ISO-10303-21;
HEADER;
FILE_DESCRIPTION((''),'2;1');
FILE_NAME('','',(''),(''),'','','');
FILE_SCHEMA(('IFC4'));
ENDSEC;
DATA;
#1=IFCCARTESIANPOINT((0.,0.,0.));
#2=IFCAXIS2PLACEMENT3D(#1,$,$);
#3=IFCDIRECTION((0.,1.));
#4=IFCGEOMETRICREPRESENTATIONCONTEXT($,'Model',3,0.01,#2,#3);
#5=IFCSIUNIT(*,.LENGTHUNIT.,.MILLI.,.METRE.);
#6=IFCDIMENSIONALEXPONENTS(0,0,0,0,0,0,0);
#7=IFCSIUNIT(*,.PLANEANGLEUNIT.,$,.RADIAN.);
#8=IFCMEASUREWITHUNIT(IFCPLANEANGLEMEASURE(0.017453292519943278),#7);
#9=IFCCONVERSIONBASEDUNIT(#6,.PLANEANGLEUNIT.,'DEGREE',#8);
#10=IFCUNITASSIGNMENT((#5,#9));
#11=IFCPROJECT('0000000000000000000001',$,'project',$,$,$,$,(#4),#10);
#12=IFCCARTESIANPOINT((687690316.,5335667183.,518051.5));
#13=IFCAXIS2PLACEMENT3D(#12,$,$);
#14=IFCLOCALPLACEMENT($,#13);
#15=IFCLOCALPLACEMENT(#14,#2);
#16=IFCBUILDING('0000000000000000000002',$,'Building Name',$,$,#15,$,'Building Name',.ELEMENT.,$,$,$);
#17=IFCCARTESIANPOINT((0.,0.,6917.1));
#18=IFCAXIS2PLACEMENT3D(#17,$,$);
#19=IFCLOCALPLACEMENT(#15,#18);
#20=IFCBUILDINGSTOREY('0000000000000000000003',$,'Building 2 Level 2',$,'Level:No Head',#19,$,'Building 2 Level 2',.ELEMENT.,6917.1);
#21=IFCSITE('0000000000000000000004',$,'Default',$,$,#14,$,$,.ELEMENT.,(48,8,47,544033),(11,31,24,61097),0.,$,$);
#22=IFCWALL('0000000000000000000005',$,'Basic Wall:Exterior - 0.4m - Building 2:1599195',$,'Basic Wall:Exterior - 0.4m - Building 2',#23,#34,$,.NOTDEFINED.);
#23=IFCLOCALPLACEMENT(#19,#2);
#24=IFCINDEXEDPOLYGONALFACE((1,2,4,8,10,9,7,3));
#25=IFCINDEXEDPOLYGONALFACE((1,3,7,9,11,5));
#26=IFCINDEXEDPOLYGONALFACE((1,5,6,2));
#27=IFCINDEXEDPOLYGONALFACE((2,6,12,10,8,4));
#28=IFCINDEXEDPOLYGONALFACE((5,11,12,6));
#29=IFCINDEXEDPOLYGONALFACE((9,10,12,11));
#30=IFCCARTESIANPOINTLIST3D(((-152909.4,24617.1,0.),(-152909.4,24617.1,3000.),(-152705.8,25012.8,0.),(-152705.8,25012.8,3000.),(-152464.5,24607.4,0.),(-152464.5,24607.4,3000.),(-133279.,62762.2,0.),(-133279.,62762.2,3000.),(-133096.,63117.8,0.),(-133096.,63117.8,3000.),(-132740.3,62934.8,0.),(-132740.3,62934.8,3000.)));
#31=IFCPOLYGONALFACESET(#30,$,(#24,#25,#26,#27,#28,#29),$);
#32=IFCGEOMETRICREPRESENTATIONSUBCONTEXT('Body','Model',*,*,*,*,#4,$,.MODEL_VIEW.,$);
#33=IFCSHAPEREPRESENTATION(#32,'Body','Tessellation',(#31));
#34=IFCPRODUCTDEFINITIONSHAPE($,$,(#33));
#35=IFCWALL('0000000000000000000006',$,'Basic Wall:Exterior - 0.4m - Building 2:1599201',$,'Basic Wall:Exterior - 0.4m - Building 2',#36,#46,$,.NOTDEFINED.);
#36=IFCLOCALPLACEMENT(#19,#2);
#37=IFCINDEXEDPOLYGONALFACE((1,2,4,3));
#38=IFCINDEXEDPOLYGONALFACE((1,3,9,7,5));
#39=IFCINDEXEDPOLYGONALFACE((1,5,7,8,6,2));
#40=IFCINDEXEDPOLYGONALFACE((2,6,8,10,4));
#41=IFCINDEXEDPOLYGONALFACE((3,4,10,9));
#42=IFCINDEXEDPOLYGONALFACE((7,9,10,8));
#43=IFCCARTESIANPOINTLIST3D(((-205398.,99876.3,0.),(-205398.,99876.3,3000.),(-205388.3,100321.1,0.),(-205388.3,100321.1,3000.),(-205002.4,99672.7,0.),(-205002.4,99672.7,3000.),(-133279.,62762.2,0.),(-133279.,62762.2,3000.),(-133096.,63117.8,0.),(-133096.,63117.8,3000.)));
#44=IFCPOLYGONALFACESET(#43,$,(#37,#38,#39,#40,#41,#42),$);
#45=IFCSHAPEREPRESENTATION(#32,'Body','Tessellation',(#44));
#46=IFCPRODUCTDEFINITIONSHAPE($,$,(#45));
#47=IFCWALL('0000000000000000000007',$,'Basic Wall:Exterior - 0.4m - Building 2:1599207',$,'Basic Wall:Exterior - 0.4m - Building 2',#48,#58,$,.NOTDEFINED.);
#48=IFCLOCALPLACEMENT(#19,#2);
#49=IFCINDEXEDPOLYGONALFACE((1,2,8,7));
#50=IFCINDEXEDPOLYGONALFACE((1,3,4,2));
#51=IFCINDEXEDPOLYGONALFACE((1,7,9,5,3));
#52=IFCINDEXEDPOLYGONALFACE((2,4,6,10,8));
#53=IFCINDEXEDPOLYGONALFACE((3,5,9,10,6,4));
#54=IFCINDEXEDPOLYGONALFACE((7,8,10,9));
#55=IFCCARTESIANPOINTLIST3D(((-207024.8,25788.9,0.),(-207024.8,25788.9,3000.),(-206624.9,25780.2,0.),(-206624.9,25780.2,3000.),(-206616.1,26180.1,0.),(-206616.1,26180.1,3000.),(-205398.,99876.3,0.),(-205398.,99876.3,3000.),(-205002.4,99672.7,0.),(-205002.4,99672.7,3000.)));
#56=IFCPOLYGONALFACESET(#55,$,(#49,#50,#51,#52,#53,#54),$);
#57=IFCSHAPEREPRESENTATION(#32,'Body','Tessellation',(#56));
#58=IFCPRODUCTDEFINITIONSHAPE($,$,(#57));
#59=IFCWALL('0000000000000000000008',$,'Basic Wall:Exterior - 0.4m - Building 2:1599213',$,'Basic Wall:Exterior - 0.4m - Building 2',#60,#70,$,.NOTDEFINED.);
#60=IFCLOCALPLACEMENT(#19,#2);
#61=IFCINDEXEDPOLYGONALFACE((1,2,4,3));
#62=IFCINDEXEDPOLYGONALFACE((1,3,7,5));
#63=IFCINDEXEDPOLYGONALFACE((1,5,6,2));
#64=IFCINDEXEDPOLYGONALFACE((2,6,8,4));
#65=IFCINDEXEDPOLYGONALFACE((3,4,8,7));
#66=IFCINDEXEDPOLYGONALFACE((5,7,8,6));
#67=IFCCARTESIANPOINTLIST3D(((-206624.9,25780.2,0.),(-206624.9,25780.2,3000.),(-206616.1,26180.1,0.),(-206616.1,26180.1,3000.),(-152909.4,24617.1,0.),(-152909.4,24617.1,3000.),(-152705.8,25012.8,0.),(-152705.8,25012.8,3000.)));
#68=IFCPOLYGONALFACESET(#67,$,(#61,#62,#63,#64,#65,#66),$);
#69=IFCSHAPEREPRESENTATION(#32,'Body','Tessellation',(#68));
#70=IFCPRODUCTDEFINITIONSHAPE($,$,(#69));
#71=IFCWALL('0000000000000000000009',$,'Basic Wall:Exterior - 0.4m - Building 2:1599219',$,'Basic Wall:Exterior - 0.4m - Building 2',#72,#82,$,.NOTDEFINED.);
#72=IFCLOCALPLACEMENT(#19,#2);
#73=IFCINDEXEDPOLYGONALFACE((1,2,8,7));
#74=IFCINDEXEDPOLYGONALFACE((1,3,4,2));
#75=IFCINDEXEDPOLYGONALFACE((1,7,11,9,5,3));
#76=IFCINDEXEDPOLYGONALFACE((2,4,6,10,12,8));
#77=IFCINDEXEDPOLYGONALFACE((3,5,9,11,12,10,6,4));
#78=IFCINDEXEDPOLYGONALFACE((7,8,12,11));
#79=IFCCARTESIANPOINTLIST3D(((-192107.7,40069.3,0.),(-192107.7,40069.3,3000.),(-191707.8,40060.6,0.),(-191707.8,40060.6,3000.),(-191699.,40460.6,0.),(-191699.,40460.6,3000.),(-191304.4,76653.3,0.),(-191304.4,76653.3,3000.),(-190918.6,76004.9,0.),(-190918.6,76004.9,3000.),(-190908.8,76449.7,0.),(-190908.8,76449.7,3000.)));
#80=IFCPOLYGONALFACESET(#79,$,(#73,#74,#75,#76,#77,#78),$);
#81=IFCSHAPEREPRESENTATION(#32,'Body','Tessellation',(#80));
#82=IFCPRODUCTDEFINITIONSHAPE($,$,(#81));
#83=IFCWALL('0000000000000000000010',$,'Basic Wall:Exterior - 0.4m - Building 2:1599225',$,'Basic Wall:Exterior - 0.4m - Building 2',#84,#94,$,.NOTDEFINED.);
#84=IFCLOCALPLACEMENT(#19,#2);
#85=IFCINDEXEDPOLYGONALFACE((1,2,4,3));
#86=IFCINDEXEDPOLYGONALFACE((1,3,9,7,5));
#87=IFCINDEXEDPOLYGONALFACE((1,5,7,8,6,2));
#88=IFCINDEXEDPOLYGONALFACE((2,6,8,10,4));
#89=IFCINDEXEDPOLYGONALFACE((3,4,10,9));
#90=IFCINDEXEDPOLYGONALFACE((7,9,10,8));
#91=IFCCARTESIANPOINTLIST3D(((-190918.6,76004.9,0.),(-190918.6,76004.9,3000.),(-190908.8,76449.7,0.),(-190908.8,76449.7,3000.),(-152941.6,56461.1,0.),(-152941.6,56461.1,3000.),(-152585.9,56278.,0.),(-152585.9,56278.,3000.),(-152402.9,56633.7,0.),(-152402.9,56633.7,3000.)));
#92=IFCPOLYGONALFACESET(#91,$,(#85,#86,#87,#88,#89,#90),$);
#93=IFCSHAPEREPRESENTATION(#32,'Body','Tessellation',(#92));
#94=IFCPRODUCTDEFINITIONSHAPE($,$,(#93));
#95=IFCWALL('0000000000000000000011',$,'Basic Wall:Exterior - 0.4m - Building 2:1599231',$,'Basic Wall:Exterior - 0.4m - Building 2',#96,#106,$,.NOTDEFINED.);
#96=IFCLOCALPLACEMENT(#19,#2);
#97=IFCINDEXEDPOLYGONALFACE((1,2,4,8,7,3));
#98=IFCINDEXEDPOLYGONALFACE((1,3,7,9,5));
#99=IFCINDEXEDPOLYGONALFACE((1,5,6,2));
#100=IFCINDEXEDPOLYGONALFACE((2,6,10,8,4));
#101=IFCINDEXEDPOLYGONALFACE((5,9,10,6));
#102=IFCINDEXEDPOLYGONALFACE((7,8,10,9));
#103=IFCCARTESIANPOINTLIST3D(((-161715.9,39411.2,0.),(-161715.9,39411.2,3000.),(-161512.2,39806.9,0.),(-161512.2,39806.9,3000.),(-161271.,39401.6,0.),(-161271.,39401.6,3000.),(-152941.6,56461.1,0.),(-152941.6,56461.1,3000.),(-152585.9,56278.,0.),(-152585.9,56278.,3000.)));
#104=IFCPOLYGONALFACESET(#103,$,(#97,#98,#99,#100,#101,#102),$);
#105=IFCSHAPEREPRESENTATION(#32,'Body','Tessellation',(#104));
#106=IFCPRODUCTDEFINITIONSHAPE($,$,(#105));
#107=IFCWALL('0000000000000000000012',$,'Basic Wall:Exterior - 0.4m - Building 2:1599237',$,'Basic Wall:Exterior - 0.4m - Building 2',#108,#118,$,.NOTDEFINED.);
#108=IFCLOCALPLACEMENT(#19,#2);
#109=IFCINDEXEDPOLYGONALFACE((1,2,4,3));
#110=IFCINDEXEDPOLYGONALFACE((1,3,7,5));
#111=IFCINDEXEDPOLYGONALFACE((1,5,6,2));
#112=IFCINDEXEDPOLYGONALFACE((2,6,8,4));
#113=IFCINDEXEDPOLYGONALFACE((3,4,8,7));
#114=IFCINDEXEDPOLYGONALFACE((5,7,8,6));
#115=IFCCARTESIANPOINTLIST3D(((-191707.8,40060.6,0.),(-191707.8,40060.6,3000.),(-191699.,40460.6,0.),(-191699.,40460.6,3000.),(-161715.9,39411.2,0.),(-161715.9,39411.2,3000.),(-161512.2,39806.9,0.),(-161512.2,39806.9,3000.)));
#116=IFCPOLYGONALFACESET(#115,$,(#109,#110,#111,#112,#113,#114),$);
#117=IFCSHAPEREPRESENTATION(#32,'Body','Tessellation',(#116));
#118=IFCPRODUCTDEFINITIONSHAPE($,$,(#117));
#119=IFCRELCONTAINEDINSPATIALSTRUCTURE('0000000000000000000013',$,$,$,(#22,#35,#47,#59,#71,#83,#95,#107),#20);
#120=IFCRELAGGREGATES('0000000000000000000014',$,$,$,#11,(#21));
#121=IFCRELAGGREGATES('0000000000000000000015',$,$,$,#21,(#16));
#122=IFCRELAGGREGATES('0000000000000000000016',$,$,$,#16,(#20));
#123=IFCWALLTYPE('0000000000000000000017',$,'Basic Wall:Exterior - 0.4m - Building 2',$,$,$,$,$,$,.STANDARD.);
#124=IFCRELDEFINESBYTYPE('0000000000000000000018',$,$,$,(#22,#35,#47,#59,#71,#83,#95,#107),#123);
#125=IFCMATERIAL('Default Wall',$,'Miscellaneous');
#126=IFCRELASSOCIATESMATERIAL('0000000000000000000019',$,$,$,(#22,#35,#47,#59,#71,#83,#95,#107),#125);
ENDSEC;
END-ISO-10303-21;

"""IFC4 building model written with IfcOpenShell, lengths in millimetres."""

from ifc_helpers import new_model, entity, si_unit, converted_unit, direction, frame, origin, place, context, subcontext, project, spatial, indexed_curve, outline, extrude, material, type_object, element, save


model = new_model("IFC4")

# Units and contexts
model_context = context("Model", 3, precision=0.01, world=origin(), true_north=direction((0.0, 1.0)))
body_context = subcontext(model_context, "Body", "Model", "MODEL_VIEW")
ifc_project = project(units=[si_unit("LENGTHUNIT", "METRE", prefix="MILLI"), converted_unit("PLANEANGLEUNIT", "DEGREE", entity("IfcPlaneAngleMeasure", 0.017453292519943278), si_unit("PLANEANGLEUNIT", "RADIAN"), dimensions=[0, 0, 0, 0, 0, 0, 0])], contexts=[model_context])

# Site, building, storey
site_placement = place(None, frame((687690316.0, 5335667183.0, 518051.5)))
site = spatial("IfcSite", under=ifc_project, at=site_placement, Name="Default", CompositionType="ELEMENT", RefLatitude=(48, 8, 47, 544033), RefLongitude=(11, 31, 24, 61097), RefElevation=0.0)
building_placement = place(site_placement, origin())
building = spatial("IfcBuilding", under=site, at=building_placement, Name="Building Name", LongName="Building Name", CompositionType="ELEMENT")
storey_placement = place(building_placement, frame((0.0, 0.0, 6917.1)))
storey = spatial("IfcBuildingStorey", under=building, at=storey_placement, Name="Building 2 Level 2", ObjectType="Level:No Head", LongName="Building 2 Level 2", CompositionType="ELEMENT", Elevation=6917.1)

# Walls
ifc_material_1 = material(Name="Default Wall", Category="Miscellaneous")
wall_type = type_object("IfcWallType", Name="Basic Wall:Exterior - 0.4m - Building 2", PredefinedType="STANDARD")
wall_1_placement = place(storey_placement, frame((-152731.6, 24525.6, 0.0), z_axis=(0.0, 0.0, 1.0), x_axis=(0.457585, 0.889166, 0.0)))
element("IfcWall", 1, at=wall_1_placement, inside=storey, type_object=wall_type, material=ifc_material_1, Name="Basic Wall:Exterior - 0.4m - Building 2:1599195", ObjectType="Basic Wall:Exterior - 0.4m - Building 2", PredefinedType="NOTDEFINED", context=body_context, shape_type="SweptSolid", body=[
    extrude(outline(indexed_curve([(43299.8, -200.0), (43299.8, 200.0), (42899.8, 200.0), (445.0, 200.0), (0.0, 200.0), (195.0, -200.0), (43299.8, -200.0)], self_intersect=False)), origin(), (0.0, 0.0, 1.0), 3000.0),
])
wall_2_placement = place(storey_placement, frame((-133187.5, 62940.0, 0.0), z_axis=(0.0, 0.0, 1.0), x_axis=(-0.889166, 0.457585, 0.0)))
element("IfcWall", 2, at=wall_2_placement, inside=storey, type_object=wall_type, material=ifc_material_1, Name="Basic Wall:Exterior - 0.4m - Building 2:1599201", ObjectType="Basic Wall:Exterior - 0.4m - Building 2", PredefinedType="NOTDEFINED", context=body_context, shape_type="SweptSolid", body=[
    extrude(outline(indexed_curve([(81303.5, -200.0), (81108.6, 200.0), (80663.7, 200.0), (0.0, 200.0), (0.0, -200.0), (81303.5, -200.0)], self_intersect=False)), origin(), (0.0, 0.0, 1.0), 3000.0),
])
wall_3_placement = place(storey_placement, frame((-205198.1, 99871.9, 0.0), z_axis=(0.0, 0.0, 1.0), x_axis=(-0.021952, -0.999759, 0.0)))
element("IfcWall", 3, at=wall_3_placement, inside=storey, type_object=wall_type, material=ifc_material_1, Name="Basic Wall:Exterior - 0.4m - Building 2:1599207", ObjectType="Basic Wall:Exterior - 0.4m - Building 2", PredefinedType="NOTDEFINED", context=body_context, shape_type="SweptSolid", body=[
    extrude(outline(indexed_curve([(74105.2, -200.0), (74105.1, 200.0), (73705.1, 200.0), (194.9, 200.0), (0.0, -200.0), (74105.2, -200.0)], self_intersect=False)), origin(), (0.0, 0.0, 1.0), 3000.0),
])
wall_4_placement = place(storey_placement, frame((-206620.6, 25980.2, 0.0), z_axis=(0.0, 0.0, 1.0), x_axis=(0.999766, -0.021649, 0.0)))
element("IfcWall", 4, at=wall_4_placement, inside=storey, type_object=wall_type, material=ifc_material_1, Name="Basic Wall:Exterior - 0.4m - Building 2:1599213", ObjectType="Basic Wall:Exterior - 0.4m - Building 2", PredefinedType="NOTDEFINED", context=body_context, shape_type="SweptSolid", body=[
    extrude(outline(indexed_curve([(53728.1, -200.0), (53923.1, 200.0), (0.1, 200.0), (0.0, -200.0), (53728.1, -200.0)], self_intersect=False)), origin(), (0.0, 0.0, 1.0), 3000.0),
])
wall_5_placement = place(storey_placement, frame((-191907.8, 40064.9, 0.0), z_axis=(0.0, 0.0, 1.0), x_axis=(0.021952, 0.999759, 0.0)))
element("IfcWall", 5, at=wall_5_placement, inside=storey, type_object=wall_type, material=ifc_material_1, Name="Basic Wall:Exterior - 0.4m - Building 2:1599219", ObjectType="Basic Wall:Exterior - 0.4m - Building 2", PredefinedType="NOTDEFINED", context=body_context, shape_type="SweptSolid", body=[
    extrude(outline(indexed_curve([(36398.0, -200.0), (36592.9, 200.0), (0.0, 200.0), (0.1, -200.0), (400.1, -200.0), (35953.1, -200.0), (36398.0, -200.0)], self_intersect=False)), origin(), (0.0, 0.0, 1.0), 3000.0),
])
wall_6_placement = place(storey_placement, frame((-191000.3, 76271.9, 0.0), z_axis=(0.0, 0.0, 1.0), x_axis=(0.889166, -0.457585, 0.0)))
element("IfcWall", 6, at=wall_6_placement, inside=storey, type_object=wall_type, material=ifc_material_1, Name="Basic Wall:Exterior - 0.4m - Building 2:1599225", ObjectType="Basic Wall:Exterior - 0.4m - Building 2", PredefinedType="NOTDEFINED", context=body_context, shape_type="SweptSolid", body=[
    extrude(outline(indexed_curve([(43305.7, -200.0), (43305.7, 200.0), (0.0, 200.0), (194.9, -200.0), (42905.7, -200.0), (43305.7, -200.0)], self_intersect=False)), origin(), (0.0, 0.0, 1.0), 3000.0),
])
wall_7_placement = place(storey_placement, frame((-152763.8, 56369.6, 0.0), z_axis=(0.0, 0.0, 1.0), x_axis=(-0.457585, -0.889166, 0.0)))
element("IfcWall", 7, at=wall_7_placement, inside=storey, type_object=wall_type, material=ifc_material_1, Name="Basic Wall:Exterior - 0.4m - Building 2:1599231", ObjectType="Basic Wall:Exterior - 0.4m - Building 2", PredefinedType="NOTDEFINED", context=body_context, shape_type="SweptSolid", body=[
    extrude(outline(indexed_curve([(19175.1, -200.0), (18980.1, 200.0), (0.0, 200.0), (0.0, -200.0), (18730.1, -200.0), (19175.1, -200.0)], self_intersect=False)), origin(), (0.0, 0.0, 1.0), 3000.0),
])
wall_8_placement = place(storey_placement, frame((-161516.6, 39606.9, 0.0), z_axis=(0.0, 0.0, 1.0), x_axis=(-0.999766, 0.021649, 0.0)))
element("IfcWall", 8, at=wall_8_placement, inside=storey, type_object=wall_type, material=ifc_material_1, Name="Basic Wall:Exterior - 0.4m - Building 2:1599237", ObjectType="Basic Wall:Exterior - 0.4m - Building 2", PredefinedType="NOTDEFINED", context=body_context, shape_type="SweptSolid", body=[
    extrude(outline(indexed_curve([(30193.9, -200.0), (30194.0, 200.0), (195.0, 200.0), (0.0, -200.0), (30193.9, -200.0)], self_intersect=False)), origin(), (0.0, 0.0, 1.0), 3000.0),
])

save(model, "model.ifc")
